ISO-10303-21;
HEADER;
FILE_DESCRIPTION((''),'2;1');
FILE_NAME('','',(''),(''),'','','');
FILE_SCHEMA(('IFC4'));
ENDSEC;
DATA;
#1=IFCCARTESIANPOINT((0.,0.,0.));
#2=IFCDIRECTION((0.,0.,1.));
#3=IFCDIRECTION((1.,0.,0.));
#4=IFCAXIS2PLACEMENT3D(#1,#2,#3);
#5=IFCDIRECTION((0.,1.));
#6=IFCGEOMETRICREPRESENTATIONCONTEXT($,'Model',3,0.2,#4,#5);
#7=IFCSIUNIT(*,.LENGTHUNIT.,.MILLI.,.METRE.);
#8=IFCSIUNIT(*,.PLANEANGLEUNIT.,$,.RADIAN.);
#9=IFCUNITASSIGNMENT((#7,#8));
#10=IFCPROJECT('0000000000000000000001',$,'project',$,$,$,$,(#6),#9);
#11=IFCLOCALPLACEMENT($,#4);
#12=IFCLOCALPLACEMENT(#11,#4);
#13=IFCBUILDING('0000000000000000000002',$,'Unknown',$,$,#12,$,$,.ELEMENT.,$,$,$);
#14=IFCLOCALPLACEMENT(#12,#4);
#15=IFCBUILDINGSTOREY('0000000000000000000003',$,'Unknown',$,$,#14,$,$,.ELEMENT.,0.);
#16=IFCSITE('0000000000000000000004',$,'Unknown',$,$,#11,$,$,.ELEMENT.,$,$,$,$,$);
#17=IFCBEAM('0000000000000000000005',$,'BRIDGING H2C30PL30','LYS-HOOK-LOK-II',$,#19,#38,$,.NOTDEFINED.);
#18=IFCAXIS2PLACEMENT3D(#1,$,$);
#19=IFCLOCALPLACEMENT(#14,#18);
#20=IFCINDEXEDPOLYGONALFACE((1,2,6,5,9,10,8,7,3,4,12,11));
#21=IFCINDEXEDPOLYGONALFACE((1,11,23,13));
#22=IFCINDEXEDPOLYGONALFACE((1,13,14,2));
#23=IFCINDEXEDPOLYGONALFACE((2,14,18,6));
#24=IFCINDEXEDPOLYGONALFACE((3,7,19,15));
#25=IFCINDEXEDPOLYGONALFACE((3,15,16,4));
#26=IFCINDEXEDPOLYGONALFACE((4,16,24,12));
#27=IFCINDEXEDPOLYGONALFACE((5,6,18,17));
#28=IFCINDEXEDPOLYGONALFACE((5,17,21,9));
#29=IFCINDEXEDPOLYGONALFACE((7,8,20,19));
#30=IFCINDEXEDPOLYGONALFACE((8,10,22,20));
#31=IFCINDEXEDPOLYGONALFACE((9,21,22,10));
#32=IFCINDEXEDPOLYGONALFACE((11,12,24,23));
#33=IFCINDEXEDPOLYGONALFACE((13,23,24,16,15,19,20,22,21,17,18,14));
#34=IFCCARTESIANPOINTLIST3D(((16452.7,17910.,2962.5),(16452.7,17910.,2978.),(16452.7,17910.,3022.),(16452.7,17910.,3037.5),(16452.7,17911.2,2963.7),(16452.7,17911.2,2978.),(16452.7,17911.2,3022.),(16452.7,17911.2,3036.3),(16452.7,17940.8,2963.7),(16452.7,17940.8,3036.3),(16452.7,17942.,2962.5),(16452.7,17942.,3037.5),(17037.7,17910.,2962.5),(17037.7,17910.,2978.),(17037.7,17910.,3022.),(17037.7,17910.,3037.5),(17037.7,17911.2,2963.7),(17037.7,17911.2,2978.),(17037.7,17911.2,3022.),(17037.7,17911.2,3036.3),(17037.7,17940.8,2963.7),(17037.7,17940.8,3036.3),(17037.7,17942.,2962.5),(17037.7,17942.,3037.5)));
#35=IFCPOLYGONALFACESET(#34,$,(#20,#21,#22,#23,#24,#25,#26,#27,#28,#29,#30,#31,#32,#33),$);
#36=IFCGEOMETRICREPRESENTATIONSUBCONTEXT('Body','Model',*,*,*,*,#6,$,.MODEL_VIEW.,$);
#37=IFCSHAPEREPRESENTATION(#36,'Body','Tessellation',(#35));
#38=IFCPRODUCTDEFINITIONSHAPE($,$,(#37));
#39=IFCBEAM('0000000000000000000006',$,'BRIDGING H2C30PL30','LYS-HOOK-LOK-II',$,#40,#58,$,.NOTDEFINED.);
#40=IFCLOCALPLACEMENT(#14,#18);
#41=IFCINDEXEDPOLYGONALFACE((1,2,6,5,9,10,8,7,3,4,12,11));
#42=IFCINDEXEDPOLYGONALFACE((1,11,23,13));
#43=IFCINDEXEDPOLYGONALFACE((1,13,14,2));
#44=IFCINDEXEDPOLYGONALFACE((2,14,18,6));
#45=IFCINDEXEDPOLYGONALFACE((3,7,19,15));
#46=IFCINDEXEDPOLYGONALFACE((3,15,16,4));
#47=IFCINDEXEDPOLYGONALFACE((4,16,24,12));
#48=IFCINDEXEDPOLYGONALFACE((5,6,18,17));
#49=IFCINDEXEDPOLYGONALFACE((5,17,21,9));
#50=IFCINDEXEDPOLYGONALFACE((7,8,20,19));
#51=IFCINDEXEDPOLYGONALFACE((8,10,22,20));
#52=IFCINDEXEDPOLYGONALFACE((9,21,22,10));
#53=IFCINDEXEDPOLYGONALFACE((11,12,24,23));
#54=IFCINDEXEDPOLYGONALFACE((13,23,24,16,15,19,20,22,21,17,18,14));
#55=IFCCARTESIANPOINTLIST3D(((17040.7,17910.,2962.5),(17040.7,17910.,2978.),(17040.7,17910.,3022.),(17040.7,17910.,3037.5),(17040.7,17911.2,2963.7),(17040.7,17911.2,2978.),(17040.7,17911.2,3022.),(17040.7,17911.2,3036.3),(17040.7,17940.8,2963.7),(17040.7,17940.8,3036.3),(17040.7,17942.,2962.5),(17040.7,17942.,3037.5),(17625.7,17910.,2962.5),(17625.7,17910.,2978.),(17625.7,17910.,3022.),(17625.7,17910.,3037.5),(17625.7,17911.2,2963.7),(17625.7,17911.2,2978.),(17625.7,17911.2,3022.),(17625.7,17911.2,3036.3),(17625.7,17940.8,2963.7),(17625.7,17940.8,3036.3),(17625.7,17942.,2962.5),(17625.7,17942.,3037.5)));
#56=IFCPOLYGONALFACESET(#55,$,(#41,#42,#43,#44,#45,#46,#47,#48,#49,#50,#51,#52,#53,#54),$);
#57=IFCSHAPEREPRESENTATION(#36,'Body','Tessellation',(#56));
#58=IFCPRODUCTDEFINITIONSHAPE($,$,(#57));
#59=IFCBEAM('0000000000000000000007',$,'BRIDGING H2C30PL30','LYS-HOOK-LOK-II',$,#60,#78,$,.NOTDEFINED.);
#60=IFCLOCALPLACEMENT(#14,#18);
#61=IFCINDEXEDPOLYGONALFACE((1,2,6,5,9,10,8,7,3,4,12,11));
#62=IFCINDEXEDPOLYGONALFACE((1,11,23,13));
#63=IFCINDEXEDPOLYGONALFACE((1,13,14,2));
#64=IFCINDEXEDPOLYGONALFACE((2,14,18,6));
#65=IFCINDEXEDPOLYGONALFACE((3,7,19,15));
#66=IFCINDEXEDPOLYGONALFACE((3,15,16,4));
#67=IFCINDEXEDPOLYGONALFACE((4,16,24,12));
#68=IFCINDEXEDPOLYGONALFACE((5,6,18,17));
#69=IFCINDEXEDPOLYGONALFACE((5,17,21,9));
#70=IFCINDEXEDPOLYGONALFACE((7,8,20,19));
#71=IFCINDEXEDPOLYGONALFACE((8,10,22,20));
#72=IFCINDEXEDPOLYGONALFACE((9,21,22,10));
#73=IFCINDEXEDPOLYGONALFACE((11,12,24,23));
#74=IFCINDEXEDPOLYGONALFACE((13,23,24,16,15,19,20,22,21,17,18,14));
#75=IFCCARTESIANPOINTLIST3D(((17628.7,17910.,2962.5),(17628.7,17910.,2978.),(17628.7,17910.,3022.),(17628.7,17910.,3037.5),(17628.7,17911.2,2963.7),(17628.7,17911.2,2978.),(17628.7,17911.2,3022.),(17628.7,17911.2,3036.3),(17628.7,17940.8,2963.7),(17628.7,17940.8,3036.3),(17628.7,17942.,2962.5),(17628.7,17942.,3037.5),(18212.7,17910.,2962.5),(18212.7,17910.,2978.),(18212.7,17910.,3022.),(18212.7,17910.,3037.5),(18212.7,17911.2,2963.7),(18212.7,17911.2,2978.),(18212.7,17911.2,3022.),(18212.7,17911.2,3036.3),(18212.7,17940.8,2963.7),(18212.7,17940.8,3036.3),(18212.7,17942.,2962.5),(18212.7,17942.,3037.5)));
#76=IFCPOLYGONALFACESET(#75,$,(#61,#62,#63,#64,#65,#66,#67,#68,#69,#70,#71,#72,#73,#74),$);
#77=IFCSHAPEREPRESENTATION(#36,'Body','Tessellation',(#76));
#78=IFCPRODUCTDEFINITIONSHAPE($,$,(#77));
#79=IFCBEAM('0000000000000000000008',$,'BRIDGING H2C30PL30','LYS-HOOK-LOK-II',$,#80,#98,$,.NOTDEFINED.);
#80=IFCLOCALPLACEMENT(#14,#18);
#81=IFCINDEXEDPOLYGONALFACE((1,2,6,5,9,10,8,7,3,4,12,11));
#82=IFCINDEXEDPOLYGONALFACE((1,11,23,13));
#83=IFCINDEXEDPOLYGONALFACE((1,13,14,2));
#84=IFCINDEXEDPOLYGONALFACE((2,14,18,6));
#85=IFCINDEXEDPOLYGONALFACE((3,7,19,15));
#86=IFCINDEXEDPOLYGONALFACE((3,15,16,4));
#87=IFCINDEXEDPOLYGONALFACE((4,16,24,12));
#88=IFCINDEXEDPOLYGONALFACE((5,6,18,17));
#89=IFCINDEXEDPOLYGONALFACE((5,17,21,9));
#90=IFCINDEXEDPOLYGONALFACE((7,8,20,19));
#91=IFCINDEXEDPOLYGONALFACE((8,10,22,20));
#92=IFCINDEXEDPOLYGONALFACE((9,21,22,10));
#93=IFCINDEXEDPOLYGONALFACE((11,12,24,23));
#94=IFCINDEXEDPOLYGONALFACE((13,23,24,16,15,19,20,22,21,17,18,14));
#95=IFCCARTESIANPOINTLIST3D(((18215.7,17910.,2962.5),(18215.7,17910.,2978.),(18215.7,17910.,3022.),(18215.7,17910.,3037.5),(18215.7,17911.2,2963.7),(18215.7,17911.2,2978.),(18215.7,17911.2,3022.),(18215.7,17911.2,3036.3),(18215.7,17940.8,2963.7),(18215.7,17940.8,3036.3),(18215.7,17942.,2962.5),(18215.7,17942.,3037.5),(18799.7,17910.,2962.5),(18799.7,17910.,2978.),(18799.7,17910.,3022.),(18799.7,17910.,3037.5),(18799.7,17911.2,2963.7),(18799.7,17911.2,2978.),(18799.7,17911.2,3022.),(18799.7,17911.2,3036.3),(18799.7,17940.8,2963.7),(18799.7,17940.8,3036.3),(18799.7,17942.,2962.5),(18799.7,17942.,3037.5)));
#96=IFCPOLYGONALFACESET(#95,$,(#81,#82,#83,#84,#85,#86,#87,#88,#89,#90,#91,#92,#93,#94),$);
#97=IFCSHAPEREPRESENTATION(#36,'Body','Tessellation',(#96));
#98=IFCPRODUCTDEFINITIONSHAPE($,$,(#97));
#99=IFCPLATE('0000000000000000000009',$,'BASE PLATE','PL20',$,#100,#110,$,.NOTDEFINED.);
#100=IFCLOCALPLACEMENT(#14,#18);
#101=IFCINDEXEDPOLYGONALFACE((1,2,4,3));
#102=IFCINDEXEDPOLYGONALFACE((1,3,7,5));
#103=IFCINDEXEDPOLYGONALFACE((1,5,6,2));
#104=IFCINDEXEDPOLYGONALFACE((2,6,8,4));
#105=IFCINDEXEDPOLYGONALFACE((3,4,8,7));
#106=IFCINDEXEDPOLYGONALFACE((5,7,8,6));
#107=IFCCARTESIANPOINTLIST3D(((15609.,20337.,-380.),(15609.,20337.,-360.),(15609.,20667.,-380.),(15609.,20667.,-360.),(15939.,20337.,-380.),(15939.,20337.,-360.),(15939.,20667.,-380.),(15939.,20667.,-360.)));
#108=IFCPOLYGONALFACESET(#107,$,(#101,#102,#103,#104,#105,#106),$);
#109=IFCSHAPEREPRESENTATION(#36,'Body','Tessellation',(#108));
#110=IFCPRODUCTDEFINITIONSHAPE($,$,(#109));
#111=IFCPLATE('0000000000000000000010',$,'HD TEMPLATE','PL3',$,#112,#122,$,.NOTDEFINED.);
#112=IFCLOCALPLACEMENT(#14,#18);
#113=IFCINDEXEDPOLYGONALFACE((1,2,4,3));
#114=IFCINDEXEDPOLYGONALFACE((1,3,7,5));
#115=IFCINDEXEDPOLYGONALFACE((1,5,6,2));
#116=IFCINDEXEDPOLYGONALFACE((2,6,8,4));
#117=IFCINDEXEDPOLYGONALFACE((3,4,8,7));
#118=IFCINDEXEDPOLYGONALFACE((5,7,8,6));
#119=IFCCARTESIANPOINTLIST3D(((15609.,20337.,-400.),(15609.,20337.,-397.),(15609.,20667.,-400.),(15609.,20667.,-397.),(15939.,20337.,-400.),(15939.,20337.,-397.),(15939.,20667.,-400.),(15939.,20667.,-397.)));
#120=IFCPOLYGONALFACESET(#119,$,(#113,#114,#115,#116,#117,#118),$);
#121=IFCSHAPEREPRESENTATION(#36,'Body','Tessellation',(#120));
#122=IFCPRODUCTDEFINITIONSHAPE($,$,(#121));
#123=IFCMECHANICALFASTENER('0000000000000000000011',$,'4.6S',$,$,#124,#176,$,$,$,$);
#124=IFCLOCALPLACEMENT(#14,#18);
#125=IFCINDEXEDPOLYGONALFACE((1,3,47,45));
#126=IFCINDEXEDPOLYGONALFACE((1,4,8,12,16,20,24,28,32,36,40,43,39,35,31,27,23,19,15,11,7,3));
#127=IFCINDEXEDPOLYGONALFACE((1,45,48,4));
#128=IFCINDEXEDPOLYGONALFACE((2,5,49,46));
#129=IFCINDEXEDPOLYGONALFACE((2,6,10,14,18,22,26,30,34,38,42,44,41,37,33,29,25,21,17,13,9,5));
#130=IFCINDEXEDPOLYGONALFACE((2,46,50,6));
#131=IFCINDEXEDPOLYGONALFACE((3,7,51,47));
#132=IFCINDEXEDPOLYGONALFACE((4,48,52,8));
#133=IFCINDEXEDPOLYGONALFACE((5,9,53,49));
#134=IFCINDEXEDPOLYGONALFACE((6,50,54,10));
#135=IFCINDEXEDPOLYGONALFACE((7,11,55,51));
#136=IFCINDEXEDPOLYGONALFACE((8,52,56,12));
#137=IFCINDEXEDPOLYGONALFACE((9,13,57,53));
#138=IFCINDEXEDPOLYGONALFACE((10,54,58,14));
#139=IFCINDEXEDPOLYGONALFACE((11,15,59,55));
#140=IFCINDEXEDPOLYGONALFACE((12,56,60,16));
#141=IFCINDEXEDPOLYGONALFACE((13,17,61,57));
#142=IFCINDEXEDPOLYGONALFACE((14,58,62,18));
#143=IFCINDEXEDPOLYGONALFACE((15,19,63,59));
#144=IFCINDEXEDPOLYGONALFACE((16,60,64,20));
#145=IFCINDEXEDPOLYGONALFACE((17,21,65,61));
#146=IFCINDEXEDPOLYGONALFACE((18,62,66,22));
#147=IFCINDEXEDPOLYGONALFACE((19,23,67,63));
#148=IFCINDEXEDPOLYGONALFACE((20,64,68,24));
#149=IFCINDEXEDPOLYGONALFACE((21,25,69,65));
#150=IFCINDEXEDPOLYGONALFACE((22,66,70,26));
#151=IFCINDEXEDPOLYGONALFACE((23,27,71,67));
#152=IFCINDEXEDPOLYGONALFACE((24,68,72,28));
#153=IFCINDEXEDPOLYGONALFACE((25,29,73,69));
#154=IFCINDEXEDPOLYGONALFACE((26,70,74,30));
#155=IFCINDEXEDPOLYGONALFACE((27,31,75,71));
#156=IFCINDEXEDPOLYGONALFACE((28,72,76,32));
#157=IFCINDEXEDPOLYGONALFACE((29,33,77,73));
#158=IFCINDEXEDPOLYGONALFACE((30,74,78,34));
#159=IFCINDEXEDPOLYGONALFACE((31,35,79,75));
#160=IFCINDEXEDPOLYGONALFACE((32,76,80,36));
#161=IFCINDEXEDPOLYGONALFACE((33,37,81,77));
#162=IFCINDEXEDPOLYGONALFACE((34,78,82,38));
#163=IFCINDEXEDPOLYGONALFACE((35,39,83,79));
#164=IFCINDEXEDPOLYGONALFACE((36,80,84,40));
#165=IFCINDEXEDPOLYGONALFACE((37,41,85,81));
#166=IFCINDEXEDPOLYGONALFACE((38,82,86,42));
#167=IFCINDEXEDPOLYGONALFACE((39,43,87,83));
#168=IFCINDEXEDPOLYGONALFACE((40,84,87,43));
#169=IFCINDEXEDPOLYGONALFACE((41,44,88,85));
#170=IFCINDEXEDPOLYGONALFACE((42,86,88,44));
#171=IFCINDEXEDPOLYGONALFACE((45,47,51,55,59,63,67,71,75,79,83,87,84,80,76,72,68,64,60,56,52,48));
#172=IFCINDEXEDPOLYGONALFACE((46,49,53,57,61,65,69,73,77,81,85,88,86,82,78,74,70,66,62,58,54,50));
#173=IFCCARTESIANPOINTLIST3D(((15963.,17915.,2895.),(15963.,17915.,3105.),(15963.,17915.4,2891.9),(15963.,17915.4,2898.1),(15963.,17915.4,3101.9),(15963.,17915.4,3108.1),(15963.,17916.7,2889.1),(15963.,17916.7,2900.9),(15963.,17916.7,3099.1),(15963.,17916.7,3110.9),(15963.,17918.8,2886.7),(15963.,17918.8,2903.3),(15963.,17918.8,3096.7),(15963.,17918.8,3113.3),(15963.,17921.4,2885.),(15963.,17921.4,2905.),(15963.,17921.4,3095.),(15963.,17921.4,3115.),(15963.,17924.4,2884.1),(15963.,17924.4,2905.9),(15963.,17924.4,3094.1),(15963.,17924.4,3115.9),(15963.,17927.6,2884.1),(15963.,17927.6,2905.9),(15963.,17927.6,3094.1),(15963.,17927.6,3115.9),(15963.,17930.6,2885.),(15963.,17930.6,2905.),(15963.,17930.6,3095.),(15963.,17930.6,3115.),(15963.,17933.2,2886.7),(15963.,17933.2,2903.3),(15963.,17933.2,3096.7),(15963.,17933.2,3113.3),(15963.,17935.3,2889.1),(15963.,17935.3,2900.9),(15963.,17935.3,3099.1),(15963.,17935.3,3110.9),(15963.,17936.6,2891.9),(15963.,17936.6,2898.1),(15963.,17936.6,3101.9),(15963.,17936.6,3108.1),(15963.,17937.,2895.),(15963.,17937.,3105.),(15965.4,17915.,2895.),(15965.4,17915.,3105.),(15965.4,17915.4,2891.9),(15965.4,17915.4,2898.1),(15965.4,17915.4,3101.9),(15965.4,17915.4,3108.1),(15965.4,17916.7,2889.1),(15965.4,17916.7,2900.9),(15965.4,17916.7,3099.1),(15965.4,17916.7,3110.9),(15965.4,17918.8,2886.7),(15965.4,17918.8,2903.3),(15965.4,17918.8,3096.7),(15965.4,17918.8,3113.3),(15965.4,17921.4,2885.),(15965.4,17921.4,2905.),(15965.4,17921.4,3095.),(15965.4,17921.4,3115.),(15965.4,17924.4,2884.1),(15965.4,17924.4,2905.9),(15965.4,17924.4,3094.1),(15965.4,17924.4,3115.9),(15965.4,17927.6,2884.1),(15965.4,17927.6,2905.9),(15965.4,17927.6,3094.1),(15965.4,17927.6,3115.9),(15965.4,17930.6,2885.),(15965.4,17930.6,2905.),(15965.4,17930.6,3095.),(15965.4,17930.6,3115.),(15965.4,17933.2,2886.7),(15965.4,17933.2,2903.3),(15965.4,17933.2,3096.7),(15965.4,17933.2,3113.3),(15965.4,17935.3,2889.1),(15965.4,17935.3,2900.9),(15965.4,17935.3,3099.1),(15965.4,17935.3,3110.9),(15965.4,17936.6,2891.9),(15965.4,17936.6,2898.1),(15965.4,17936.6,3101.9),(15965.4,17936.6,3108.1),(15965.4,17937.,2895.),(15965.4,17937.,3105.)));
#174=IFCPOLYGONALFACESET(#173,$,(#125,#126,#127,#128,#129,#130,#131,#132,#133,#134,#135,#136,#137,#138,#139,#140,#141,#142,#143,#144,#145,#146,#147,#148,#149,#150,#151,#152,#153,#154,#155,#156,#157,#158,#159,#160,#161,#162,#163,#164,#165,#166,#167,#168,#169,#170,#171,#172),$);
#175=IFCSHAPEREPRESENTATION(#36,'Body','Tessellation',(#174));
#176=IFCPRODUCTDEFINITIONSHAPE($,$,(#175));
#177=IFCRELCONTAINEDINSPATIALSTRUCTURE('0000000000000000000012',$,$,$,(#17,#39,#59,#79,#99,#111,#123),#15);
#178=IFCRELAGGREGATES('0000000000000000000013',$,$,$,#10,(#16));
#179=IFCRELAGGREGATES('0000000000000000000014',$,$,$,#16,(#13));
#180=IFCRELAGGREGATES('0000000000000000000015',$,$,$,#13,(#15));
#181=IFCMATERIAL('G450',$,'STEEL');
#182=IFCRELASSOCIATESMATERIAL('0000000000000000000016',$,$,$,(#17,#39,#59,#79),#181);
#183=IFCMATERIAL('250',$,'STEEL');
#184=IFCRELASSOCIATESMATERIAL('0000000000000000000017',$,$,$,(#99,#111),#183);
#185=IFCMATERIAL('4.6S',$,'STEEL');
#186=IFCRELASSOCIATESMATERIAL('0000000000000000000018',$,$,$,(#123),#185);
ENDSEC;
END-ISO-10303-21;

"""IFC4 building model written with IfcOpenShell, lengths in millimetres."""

from ifc_helpers import new_model, si_unit, direction, frame, origin_with_axes, place, context, subcontext, project, spatial, line, arc, indexed_curve, outline, extrude, source, transform, mapped, material, element, save


model = new_model("IFC4")

# Units and contexts
model_context = context("Model", 3, precision=0.2, world=origin_with_axes(), true_north=direction((0.0, 1.0)))
body_context = subcontext(model_context, "Body", "Model", "MODEL_VIEW")
ifc_project = project(units=[si_unit("LENGTHUNIT", "METRE", prefix="MILLI"), si_unit("PLANEANGLEUNIT", "RADIAN")], contexts=[model_context])

# Site, building, storey
site_placement = place(None, origin_with_axes())
site = spatial("IfcSite", under=ifc_project, at=site_placement, Name="Unknown", CompositionType="ELEMENT")
building_placement = place(site_placement, origin_with_axes())
building = spatial("IfcBuilding", under=site, at=building_placement, Name="Unknown", CompositionType="ELEMENT")
storey_placement = place(building_placement, origin_with_axes())
storey = spatial("IfcBuildingStorey", under=building, at=storey_placement, Name="Unknown", CompositionType="ELEMENT", Elevation=0.0)

# Shared definitions
ifc_material_1 = material(Name="250", Category="STEEL")

# Beams
ifc_material_2 = material(Name="G450", Category="STEEL")
for number, where, z_axis, x_axis, name in (
    (1, (16452.7, 17926.0, 3000.0), (0.0, -1.0, 0.0), (1.0, 0.0, 0.0), "BRIDGING H2C30PL30"),
    (2, (17040.7, 17926.0, 3000.0), (0.0, -1.0, 0.0), (1.0, 0.0, 0.0), "BRIDGING H2C30PL30"),
):
    element("IfcBeam", number, at=place(storey_placement, frame(where, z_axis=z_axis, x_axis=x_axis)), inside=storey, material=ifc_material_2, Name=name, Description="LYS-HOOK-LOK-II", PredefinedType="NOTDEFINED", context=body_context, shape_type="SolidModel", body=[
        extrude(outline(indexed_curve([(16.0, -37.5), (16.0, -22.0), (14.8, -22.0), (14.8, -36.3), (-14.8, -36.3), (-14.8, 36.3), (14.8, 36.3), (14.8, 22.0), (16.0, 22.0), (16.0, 37.5), (-16.0, 37.5), (-16.0, -37.5)], segments=[line(1, 2, 3, 4, 5, 6, 7, 8, 9, 10, 11, 12, 1)])), frame((0.0, 0.0, 0.0), z_axis=(-1.0, 0.0, 0.0), x_axis=(0.0, 0.0, 1.0)), (0.0, 0.0, -1.0), 585.0),
    ])
for number, where, z_axis, x_axis, name in (
    (3, (17628.7, 17926.0, 3000.0), (0.0, -1.0, 0.0), (1.0, 0.0, 0.0), "BRIDGING H2C30PL30"),
    (4, (18215.7, 17926.0, 3000.0), (0.0, -1.0, 0.0), (1.0, 0.0, 0.0), "BRIDGING H2C30PL30"),
):
    element("IfcBeam", number, at=place(storey_placement, frame(where, z_axis=z_axis, x_axis=x_axis)), inside=storey, material=ifc_material_2, Name=name, Description="LYS-HOOK-LOK-II", PredefinedType="NOTDEFINED", context=body_context, shape_type="SolidModel", body=[
        extrude(outline(indexed_curve([(16.0, -37.5), (16.0, -22.0), (14.8, -22.0), (14.8, -36.3), (-14.8, -36.3), (-14.8, 36.3), (14.8, 36.3), (14.8, 22.0), (16.0, 22.0), (16.0, 37.5), (-16.0, 37.5), (-16.0, -37.5)], segments=[line(1, 2, 3, 4, 5, 6, 7, 8, 9, 10, 11, 12, 1)])), frame((0.0, 0.0, 0.0), z_axis=(-1.0, 0.0, 0.0), x_axis=(0.0, 0.0, 1.0)), (0.0, 0.0, -1.0), 584.0),
    ])

# Plates
plate_1_placement = place(storey_placement, frame((15609.0, 20337.0, -370.0), z_axis=(0.0, 0.0, 1.0), x_axis=(1.0, 0.0, 0.0)))
element("IfcPlate", 5, at=plate_1_placement, inside=storey, material=ifc_material_1, Name="BASE PLATE", Description="PL20", PredefinedType="NOTDEFINED", context=body_context, shape_type="SolidModel", body=[
    extrude(outline(indexed_curve([(0.0, 0.0), (330.0, 0.0), (330.0, 330.0), (0.0, 330.0)], segments=[line(1, 2, 3, 4, 1)])), frame((0.0, 0.0, 10.0), z_axis=(0.0, 0.0, 1.0), x_axis=(1.0, 0.0, 0.0)), (0.0, 0.0, -1.0), 20.0),
])
plate_2_placement = place(storey_placement, frame((15609.0, 20337.0, -398.5), z_axis=(0.0, 0.0, 1.0), x_axis=(1.0, 0.0, 0.0)))
element("IfcPlate", 6, at=plate_2_placement, inside=storey, material=ifc_material_1, Name="HD TEMPLATE", Description="PL3", PredefinedType="NOTDEFINED", context=body_context, shape_type="SolidModel", body=[
    extrude(outline(indexed_curve([(0.0, 0.0), (330.0, 0.0), (330.0, 330.0), (0.0, 330.0)], segments=[line(1, 2, 3, 4, 1)])), frame((0.0, 0.0, 1.5), z_axis=(0.0, 0.0, 1.0), x_axis=(1.0, 0.0, 0.0)), (0.0, 0.0, -1.0), 3.0),
])

# Mechanical fastener
ifc_material_3 = material(Name="4.6S", Category="STEEL")
shared_shape_1 = source(origin_with_axes(), body_context, "Body", "SweptSolid", [
    extrude(outline(indexed_curve([(11.0, 0.0), (0.0, 11.0), (-11.0, 0.0), (0.0, -11.0)], segments=[arc(1, 2, 3), arc(3, 4, 1)])), frame((0.0, 0.0, 1.2), z_axis=(0.0, 0.0, -1.0), x_axis=(0.0, 1.0, 0.0)), (0.0, 0.0, 1.0), 2.4),
])
for number, where, z_axis, x_axis, name in (
    (7, (15964.2, 17926.0, 2895.0), (-1.0, 0.0, 0.0), (0.0, 0.0, 1.0), "4.6S"),
):
    element("IfcMechanicalFastener", number, at=place(storey_placement, frame(where, z_axis=z_axis, x_axis=x_axis)), inside=storey, material=ifc_material_3, Name=name, context=body_context, shape_type="MappedRepresentation", body=[
        mapped(shared_shape_1, transform((0.0, 0.0, 0.0))),
        mapped(shared_shape_1, transform((210.0, 0.0, 0.0))),
    ])

save(model, "model.ifc")
